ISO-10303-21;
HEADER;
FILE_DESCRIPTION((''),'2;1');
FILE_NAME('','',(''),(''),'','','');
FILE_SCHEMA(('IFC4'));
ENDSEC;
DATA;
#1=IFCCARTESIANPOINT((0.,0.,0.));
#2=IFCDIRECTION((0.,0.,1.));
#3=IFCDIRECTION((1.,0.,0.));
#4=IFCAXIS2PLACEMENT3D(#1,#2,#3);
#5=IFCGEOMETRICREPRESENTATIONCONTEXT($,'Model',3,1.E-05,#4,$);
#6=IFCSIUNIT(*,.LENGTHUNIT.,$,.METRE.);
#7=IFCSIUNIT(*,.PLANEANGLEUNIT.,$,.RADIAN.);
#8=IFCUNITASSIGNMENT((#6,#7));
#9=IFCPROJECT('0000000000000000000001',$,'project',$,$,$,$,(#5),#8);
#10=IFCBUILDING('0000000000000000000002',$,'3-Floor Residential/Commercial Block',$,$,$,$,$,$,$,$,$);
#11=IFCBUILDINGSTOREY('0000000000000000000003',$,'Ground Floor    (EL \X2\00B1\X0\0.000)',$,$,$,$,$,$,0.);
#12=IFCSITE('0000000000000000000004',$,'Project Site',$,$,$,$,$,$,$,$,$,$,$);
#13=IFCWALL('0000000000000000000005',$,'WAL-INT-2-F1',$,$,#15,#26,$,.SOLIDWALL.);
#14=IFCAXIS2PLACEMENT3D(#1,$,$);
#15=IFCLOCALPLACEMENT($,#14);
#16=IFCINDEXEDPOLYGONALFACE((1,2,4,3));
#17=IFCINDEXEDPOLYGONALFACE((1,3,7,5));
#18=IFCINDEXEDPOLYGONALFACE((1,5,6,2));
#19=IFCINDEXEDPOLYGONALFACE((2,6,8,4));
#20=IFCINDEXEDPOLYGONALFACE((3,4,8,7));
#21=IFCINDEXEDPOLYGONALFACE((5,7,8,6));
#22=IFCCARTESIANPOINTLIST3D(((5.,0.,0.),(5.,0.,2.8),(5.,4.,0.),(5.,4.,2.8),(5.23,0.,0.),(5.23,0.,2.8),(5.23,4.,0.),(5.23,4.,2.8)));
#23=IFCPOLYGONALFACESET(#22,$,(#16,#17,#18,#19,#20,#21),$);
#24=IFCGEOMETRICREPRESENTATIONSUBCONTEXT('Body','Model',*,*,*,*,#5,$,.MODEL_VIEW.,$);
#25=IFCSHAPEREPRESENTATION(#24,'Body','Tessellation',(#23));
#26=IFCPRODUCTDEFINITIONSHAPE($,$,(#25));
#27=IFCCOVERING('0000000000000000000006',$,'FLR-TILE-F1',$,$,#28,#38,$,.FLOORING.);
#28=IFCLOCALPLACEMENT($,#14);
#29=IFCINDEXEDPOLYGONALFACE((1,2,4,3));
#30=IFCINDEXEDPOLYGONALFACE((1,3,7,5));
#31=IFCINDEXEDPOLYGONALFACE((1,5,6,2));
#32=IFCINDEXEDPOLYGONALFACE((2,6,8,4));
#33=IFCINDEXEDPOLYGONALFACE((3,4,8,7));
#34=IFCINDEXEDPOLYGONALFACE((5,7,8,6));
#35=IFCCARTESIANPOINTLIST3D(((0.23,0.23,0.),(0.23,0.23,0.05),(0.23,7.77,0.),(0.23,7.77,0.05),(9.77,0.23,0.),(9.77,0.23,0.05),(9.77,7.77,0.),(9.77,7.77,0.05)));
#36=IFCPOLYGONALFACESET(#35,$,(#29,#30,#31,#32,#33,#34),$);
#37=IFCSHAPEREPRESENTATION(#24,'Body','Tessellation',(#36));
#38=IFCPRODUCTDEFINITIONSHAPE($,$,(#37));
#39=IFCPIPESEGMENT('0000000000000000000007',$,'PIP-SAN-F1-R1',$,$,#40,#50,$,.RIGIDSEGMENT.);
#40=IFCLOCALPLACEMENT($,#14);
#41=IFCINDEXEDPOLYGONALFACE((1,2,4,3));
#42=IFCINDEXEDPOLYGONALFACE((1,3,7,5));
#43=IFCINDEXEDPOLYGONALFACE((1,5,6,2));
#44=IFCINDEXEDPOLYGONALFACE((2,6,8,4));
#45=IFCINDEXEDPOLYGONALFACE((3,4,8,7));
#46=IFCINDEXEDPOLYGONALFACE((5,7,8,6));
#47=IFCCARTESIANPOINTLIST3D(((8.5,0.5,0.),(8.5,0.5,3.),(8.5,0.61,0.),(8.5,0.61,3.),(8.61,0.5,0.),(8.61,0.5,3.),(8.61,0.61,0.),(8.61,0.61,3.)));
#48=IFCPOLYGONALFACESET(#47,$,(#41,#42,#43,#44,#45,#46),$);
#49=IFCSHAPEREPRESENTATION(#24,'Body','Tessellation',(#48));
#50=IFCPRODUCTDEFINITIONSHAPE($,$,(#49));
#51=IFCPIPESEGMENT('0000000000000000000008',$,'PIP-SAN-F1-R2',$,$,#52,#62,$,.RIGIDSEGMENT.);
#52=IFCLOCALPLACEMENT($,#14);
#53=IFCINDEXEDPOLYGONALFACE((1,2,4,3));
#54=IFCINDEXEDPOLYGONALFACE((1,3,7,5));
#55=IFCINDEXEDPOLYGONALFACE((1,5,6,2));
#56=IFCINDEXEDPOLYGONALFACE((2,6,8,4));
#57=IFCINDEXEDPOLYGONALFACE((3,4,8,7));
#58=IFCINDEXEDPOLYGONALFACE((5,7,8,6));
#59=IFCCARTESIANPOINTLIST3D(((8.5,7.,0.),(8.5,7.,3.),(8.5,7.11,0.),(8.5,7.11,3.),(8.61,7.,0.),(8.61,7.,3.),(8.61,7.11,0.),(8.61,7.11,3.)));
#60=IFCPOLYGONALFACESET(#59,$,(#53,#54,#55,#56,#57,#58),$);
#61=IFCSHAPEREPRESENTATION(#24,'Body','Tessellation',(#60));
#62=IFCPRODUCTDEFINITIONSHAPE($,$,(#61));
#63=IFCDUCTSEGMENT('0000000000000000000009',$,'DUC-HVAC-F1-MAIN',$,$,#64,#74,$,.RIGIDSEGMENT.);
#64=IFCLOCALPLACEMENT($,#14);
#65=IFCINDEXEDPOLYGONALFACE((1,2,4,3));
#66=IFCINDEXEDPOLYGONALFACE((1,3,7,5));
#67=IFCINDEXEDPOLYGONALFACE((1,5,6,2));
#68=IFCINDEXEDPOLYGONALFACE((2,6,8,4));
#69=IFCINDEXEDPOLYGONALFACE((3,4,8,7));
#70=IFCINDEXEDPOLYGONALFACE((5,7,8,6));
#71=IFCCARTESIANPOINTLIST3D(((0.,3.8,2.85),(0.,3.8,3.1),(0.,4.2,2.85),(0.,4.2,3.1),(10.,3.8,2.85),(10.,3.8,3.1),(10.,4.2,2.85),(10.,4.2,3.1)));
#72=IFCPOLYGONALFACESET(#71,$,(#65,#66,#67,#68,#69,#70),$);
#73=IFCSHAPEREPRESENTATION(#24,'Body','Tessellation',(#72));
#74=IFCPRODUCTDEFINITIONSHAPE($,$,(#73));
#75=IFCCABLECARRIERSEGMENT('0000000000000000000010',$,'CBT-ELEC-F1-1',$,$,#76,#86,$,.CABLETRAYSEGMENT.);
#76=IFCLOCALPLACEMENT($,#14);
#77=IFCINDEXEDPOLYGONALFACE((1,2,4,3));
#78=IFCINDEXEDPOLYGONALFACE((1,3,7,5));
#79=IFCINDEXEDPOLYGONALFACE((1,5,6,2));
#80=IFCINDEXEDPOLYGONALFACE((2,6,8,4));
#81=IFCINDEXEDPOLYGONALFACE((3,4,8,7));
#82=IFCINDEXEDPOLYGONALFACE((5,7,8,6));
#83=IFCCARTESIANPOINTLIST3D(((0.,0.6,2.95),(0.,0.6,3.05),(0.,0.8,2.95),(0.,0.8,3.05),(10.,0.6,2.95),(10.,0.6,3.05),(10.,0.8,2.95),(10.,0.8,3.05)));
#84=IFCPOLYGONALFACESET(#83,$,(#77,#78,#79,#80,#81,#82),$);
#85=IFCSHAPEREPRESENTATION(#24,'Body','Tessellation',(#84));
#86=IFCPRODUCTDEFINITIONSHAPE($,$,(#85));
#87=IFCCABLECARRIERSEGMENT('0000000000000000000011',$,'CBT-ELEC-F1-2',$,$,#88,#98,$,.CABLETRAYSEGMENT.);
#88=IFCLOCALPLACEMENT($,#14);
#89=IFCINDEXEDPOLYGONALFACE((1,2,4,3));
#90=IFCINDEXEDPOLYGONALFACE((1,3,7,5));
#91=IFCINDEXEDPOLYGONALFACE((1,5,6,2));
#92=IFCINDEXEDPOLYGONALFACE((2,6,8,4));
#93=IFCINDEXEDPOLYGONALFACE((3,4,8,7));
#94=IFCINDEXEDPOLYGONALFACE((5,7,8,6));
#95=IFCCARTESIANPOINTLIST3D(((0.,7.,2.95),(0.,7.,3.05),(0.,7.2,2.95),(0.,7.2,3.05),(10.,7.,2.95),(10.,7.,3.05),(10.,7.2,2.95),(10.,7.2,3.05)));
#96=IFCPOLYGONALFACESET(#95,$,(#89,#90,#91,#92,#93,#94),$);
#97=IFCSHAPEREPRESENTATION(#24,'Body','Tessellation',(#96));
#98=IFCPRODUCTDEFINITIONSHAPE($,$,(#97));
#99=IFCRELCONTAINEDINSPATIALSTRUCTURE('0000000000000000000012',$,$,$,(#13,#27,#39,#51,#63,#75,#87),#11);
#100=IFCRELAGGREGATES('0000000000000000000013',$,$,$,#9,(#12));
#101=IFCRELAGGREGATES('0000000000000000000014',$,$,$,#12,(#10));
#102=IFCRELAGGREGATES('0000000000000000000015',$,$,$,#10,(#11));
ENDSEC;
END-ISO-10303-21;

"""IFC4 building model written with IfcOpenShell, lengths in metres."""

from ifc_helpers import new_model, si_unit, frame, frame_2d, origin_with_axes, place, context, subcontext, project, spatial, rectangle, extrude, element, save


model = new_model("IFC4")

# Units and contexts
model_context = context("Model", 3, precision=1e-05, world=origin_with_axes())
body_context = subcontext(model_context, "Body", "Model", "MODEL_VIEW")
ifc_project = project(units=[si_unit("LENGTHUNIT", "METRE"), si_unit("PLANEANGLEUNIT", "RADIAN")], contexts=[model_context])

# Site, building, storey
site = spatial("IfcSite", under=ifc_project, Name="Project Site")
building = spatial("IfcBuilding", under=site, Name="3-Floor Residential/Commercial Block")
storey = spatial("IfcBuildingStorey", under=building, Name="Ground Floor    (EL ±0.000)", Elevation=0.0)

# Wall
wall_1_placement = place(None, frame((5.0, 0.0, 0.0), z_axis=(0.0, 0.0, 1.0), x_axis=(1.0, 0.0, 0.0)))
element("IfcWall", 1, at=wall_1_placement, inside=storey, Name="WAL-INT-2-F1", PredefinedType="SOLIDWALL", context=body_context, shape_type="SweptSolid", body=[
    extrude(rectangle(XDim=0.23, YDim=4.0, at=frame_2d((0.115, 2.0))), origin_with_axes(), (0.0, 0.0, 1.0), 2.8),
])

# Covering
covering_placement = place(None, frame((0.23, 0.23, 0.0), z_axis=(0.0, 0.0, 1.0), x_axis=(1.0, 0.0, 0.0)))
element("IfcCovering", 2, at=covering_placement, inside=storey, Name="FLR-TILE-F1", PredefinedType="FLOORING", context=body_context, shape_type="SweptSolid", body=[
    extrude(rectangle(XDim=9.54, YDim=7.54, at=frame_2d((4.77, 3.77))), origin_with_axes(), (0.0, 0.0, 1.0), 0.05),
])

# Pipe segments
for number, where, z_axis, x_axis, name in (
    (3, (8.5, 0.5, 0.0), (0.0, 0.0, 1.0), (1.0, 0.0, 0.0), "PIP-SAN-F1-R1"),
    (4, (8.5, 7.0, 0.0), (0.0, 0.0, 1.0), (1.0, 0.0, 0.0), "PIP-SAN-F1-R2"),
):
    element("IfcPipeSegment", number, at=place(None, frame(where, z_axis=z_axis, x_axis=x_axis)), inside=storey, Name=name, PredefinedType="RIGIDSEGMENT", context=body_context, shape_type="SweptSolid", body=[
        extrude(rectangle(XDim=0.11, YDim=0.11, at=frame_2d((0.055, 0.055))), origin_with_axes(), (0.0, 0.0, 1.0), 3.0),
    ])

# Duct segment
duct_segment_placement = place(None, frame((0.0, 3.8, 2.85), z_axis=(0.0, 0.0, 1.0), x_axis=(1.0, 0.0, 0.0)))
element("IfcDuctSegment", 5, at=duct_segment_placement, inside=storey, Name="DUC-HVAC-F1-MAIN", PredefinedType="RIGIDSEGMENT", context=body_context, shape_type="SweptSolid", body=[
    extrude(rectangle(XDim=10.0, YDim=0.4, at=frame_2d((5.0, 0.2))), origin_with_axes(), (0.0, 0.0, 1.0), 0.25),
])

# Cable carrier segments
for number, where, z_axis, x_axis, name in (
    (6, (0.0, 0.6, 2.95), (0.0, 0.0, 1.0), (1.0, 0.0, 0.0), "CBT-ELEC-F1-1"),
    (7, (0.0, 7.0, 2.95), (0.0, 0.0, 1.0), (1.0, 0.0, 0.0), "CBT-ELEC-F1-2"),
):
    element("IfcCableCarrierSegment", number, at=place(None, frame(where, z_axis=z_axis, x_axis=x_axis)), inside=storey, Name=name, PredefinedType="CABLETRAYSEGMENT", context=body_context, shape_type="SweptSolid", body=[
        extrude(rectangle(XDim=10.0, YDim=0.2, at=frame_2d((5.0, 0.1))), origin_with_axes(), (0.0, 0.0, 1.0), 0.1),
    ])

save(model, "model.ifc")
